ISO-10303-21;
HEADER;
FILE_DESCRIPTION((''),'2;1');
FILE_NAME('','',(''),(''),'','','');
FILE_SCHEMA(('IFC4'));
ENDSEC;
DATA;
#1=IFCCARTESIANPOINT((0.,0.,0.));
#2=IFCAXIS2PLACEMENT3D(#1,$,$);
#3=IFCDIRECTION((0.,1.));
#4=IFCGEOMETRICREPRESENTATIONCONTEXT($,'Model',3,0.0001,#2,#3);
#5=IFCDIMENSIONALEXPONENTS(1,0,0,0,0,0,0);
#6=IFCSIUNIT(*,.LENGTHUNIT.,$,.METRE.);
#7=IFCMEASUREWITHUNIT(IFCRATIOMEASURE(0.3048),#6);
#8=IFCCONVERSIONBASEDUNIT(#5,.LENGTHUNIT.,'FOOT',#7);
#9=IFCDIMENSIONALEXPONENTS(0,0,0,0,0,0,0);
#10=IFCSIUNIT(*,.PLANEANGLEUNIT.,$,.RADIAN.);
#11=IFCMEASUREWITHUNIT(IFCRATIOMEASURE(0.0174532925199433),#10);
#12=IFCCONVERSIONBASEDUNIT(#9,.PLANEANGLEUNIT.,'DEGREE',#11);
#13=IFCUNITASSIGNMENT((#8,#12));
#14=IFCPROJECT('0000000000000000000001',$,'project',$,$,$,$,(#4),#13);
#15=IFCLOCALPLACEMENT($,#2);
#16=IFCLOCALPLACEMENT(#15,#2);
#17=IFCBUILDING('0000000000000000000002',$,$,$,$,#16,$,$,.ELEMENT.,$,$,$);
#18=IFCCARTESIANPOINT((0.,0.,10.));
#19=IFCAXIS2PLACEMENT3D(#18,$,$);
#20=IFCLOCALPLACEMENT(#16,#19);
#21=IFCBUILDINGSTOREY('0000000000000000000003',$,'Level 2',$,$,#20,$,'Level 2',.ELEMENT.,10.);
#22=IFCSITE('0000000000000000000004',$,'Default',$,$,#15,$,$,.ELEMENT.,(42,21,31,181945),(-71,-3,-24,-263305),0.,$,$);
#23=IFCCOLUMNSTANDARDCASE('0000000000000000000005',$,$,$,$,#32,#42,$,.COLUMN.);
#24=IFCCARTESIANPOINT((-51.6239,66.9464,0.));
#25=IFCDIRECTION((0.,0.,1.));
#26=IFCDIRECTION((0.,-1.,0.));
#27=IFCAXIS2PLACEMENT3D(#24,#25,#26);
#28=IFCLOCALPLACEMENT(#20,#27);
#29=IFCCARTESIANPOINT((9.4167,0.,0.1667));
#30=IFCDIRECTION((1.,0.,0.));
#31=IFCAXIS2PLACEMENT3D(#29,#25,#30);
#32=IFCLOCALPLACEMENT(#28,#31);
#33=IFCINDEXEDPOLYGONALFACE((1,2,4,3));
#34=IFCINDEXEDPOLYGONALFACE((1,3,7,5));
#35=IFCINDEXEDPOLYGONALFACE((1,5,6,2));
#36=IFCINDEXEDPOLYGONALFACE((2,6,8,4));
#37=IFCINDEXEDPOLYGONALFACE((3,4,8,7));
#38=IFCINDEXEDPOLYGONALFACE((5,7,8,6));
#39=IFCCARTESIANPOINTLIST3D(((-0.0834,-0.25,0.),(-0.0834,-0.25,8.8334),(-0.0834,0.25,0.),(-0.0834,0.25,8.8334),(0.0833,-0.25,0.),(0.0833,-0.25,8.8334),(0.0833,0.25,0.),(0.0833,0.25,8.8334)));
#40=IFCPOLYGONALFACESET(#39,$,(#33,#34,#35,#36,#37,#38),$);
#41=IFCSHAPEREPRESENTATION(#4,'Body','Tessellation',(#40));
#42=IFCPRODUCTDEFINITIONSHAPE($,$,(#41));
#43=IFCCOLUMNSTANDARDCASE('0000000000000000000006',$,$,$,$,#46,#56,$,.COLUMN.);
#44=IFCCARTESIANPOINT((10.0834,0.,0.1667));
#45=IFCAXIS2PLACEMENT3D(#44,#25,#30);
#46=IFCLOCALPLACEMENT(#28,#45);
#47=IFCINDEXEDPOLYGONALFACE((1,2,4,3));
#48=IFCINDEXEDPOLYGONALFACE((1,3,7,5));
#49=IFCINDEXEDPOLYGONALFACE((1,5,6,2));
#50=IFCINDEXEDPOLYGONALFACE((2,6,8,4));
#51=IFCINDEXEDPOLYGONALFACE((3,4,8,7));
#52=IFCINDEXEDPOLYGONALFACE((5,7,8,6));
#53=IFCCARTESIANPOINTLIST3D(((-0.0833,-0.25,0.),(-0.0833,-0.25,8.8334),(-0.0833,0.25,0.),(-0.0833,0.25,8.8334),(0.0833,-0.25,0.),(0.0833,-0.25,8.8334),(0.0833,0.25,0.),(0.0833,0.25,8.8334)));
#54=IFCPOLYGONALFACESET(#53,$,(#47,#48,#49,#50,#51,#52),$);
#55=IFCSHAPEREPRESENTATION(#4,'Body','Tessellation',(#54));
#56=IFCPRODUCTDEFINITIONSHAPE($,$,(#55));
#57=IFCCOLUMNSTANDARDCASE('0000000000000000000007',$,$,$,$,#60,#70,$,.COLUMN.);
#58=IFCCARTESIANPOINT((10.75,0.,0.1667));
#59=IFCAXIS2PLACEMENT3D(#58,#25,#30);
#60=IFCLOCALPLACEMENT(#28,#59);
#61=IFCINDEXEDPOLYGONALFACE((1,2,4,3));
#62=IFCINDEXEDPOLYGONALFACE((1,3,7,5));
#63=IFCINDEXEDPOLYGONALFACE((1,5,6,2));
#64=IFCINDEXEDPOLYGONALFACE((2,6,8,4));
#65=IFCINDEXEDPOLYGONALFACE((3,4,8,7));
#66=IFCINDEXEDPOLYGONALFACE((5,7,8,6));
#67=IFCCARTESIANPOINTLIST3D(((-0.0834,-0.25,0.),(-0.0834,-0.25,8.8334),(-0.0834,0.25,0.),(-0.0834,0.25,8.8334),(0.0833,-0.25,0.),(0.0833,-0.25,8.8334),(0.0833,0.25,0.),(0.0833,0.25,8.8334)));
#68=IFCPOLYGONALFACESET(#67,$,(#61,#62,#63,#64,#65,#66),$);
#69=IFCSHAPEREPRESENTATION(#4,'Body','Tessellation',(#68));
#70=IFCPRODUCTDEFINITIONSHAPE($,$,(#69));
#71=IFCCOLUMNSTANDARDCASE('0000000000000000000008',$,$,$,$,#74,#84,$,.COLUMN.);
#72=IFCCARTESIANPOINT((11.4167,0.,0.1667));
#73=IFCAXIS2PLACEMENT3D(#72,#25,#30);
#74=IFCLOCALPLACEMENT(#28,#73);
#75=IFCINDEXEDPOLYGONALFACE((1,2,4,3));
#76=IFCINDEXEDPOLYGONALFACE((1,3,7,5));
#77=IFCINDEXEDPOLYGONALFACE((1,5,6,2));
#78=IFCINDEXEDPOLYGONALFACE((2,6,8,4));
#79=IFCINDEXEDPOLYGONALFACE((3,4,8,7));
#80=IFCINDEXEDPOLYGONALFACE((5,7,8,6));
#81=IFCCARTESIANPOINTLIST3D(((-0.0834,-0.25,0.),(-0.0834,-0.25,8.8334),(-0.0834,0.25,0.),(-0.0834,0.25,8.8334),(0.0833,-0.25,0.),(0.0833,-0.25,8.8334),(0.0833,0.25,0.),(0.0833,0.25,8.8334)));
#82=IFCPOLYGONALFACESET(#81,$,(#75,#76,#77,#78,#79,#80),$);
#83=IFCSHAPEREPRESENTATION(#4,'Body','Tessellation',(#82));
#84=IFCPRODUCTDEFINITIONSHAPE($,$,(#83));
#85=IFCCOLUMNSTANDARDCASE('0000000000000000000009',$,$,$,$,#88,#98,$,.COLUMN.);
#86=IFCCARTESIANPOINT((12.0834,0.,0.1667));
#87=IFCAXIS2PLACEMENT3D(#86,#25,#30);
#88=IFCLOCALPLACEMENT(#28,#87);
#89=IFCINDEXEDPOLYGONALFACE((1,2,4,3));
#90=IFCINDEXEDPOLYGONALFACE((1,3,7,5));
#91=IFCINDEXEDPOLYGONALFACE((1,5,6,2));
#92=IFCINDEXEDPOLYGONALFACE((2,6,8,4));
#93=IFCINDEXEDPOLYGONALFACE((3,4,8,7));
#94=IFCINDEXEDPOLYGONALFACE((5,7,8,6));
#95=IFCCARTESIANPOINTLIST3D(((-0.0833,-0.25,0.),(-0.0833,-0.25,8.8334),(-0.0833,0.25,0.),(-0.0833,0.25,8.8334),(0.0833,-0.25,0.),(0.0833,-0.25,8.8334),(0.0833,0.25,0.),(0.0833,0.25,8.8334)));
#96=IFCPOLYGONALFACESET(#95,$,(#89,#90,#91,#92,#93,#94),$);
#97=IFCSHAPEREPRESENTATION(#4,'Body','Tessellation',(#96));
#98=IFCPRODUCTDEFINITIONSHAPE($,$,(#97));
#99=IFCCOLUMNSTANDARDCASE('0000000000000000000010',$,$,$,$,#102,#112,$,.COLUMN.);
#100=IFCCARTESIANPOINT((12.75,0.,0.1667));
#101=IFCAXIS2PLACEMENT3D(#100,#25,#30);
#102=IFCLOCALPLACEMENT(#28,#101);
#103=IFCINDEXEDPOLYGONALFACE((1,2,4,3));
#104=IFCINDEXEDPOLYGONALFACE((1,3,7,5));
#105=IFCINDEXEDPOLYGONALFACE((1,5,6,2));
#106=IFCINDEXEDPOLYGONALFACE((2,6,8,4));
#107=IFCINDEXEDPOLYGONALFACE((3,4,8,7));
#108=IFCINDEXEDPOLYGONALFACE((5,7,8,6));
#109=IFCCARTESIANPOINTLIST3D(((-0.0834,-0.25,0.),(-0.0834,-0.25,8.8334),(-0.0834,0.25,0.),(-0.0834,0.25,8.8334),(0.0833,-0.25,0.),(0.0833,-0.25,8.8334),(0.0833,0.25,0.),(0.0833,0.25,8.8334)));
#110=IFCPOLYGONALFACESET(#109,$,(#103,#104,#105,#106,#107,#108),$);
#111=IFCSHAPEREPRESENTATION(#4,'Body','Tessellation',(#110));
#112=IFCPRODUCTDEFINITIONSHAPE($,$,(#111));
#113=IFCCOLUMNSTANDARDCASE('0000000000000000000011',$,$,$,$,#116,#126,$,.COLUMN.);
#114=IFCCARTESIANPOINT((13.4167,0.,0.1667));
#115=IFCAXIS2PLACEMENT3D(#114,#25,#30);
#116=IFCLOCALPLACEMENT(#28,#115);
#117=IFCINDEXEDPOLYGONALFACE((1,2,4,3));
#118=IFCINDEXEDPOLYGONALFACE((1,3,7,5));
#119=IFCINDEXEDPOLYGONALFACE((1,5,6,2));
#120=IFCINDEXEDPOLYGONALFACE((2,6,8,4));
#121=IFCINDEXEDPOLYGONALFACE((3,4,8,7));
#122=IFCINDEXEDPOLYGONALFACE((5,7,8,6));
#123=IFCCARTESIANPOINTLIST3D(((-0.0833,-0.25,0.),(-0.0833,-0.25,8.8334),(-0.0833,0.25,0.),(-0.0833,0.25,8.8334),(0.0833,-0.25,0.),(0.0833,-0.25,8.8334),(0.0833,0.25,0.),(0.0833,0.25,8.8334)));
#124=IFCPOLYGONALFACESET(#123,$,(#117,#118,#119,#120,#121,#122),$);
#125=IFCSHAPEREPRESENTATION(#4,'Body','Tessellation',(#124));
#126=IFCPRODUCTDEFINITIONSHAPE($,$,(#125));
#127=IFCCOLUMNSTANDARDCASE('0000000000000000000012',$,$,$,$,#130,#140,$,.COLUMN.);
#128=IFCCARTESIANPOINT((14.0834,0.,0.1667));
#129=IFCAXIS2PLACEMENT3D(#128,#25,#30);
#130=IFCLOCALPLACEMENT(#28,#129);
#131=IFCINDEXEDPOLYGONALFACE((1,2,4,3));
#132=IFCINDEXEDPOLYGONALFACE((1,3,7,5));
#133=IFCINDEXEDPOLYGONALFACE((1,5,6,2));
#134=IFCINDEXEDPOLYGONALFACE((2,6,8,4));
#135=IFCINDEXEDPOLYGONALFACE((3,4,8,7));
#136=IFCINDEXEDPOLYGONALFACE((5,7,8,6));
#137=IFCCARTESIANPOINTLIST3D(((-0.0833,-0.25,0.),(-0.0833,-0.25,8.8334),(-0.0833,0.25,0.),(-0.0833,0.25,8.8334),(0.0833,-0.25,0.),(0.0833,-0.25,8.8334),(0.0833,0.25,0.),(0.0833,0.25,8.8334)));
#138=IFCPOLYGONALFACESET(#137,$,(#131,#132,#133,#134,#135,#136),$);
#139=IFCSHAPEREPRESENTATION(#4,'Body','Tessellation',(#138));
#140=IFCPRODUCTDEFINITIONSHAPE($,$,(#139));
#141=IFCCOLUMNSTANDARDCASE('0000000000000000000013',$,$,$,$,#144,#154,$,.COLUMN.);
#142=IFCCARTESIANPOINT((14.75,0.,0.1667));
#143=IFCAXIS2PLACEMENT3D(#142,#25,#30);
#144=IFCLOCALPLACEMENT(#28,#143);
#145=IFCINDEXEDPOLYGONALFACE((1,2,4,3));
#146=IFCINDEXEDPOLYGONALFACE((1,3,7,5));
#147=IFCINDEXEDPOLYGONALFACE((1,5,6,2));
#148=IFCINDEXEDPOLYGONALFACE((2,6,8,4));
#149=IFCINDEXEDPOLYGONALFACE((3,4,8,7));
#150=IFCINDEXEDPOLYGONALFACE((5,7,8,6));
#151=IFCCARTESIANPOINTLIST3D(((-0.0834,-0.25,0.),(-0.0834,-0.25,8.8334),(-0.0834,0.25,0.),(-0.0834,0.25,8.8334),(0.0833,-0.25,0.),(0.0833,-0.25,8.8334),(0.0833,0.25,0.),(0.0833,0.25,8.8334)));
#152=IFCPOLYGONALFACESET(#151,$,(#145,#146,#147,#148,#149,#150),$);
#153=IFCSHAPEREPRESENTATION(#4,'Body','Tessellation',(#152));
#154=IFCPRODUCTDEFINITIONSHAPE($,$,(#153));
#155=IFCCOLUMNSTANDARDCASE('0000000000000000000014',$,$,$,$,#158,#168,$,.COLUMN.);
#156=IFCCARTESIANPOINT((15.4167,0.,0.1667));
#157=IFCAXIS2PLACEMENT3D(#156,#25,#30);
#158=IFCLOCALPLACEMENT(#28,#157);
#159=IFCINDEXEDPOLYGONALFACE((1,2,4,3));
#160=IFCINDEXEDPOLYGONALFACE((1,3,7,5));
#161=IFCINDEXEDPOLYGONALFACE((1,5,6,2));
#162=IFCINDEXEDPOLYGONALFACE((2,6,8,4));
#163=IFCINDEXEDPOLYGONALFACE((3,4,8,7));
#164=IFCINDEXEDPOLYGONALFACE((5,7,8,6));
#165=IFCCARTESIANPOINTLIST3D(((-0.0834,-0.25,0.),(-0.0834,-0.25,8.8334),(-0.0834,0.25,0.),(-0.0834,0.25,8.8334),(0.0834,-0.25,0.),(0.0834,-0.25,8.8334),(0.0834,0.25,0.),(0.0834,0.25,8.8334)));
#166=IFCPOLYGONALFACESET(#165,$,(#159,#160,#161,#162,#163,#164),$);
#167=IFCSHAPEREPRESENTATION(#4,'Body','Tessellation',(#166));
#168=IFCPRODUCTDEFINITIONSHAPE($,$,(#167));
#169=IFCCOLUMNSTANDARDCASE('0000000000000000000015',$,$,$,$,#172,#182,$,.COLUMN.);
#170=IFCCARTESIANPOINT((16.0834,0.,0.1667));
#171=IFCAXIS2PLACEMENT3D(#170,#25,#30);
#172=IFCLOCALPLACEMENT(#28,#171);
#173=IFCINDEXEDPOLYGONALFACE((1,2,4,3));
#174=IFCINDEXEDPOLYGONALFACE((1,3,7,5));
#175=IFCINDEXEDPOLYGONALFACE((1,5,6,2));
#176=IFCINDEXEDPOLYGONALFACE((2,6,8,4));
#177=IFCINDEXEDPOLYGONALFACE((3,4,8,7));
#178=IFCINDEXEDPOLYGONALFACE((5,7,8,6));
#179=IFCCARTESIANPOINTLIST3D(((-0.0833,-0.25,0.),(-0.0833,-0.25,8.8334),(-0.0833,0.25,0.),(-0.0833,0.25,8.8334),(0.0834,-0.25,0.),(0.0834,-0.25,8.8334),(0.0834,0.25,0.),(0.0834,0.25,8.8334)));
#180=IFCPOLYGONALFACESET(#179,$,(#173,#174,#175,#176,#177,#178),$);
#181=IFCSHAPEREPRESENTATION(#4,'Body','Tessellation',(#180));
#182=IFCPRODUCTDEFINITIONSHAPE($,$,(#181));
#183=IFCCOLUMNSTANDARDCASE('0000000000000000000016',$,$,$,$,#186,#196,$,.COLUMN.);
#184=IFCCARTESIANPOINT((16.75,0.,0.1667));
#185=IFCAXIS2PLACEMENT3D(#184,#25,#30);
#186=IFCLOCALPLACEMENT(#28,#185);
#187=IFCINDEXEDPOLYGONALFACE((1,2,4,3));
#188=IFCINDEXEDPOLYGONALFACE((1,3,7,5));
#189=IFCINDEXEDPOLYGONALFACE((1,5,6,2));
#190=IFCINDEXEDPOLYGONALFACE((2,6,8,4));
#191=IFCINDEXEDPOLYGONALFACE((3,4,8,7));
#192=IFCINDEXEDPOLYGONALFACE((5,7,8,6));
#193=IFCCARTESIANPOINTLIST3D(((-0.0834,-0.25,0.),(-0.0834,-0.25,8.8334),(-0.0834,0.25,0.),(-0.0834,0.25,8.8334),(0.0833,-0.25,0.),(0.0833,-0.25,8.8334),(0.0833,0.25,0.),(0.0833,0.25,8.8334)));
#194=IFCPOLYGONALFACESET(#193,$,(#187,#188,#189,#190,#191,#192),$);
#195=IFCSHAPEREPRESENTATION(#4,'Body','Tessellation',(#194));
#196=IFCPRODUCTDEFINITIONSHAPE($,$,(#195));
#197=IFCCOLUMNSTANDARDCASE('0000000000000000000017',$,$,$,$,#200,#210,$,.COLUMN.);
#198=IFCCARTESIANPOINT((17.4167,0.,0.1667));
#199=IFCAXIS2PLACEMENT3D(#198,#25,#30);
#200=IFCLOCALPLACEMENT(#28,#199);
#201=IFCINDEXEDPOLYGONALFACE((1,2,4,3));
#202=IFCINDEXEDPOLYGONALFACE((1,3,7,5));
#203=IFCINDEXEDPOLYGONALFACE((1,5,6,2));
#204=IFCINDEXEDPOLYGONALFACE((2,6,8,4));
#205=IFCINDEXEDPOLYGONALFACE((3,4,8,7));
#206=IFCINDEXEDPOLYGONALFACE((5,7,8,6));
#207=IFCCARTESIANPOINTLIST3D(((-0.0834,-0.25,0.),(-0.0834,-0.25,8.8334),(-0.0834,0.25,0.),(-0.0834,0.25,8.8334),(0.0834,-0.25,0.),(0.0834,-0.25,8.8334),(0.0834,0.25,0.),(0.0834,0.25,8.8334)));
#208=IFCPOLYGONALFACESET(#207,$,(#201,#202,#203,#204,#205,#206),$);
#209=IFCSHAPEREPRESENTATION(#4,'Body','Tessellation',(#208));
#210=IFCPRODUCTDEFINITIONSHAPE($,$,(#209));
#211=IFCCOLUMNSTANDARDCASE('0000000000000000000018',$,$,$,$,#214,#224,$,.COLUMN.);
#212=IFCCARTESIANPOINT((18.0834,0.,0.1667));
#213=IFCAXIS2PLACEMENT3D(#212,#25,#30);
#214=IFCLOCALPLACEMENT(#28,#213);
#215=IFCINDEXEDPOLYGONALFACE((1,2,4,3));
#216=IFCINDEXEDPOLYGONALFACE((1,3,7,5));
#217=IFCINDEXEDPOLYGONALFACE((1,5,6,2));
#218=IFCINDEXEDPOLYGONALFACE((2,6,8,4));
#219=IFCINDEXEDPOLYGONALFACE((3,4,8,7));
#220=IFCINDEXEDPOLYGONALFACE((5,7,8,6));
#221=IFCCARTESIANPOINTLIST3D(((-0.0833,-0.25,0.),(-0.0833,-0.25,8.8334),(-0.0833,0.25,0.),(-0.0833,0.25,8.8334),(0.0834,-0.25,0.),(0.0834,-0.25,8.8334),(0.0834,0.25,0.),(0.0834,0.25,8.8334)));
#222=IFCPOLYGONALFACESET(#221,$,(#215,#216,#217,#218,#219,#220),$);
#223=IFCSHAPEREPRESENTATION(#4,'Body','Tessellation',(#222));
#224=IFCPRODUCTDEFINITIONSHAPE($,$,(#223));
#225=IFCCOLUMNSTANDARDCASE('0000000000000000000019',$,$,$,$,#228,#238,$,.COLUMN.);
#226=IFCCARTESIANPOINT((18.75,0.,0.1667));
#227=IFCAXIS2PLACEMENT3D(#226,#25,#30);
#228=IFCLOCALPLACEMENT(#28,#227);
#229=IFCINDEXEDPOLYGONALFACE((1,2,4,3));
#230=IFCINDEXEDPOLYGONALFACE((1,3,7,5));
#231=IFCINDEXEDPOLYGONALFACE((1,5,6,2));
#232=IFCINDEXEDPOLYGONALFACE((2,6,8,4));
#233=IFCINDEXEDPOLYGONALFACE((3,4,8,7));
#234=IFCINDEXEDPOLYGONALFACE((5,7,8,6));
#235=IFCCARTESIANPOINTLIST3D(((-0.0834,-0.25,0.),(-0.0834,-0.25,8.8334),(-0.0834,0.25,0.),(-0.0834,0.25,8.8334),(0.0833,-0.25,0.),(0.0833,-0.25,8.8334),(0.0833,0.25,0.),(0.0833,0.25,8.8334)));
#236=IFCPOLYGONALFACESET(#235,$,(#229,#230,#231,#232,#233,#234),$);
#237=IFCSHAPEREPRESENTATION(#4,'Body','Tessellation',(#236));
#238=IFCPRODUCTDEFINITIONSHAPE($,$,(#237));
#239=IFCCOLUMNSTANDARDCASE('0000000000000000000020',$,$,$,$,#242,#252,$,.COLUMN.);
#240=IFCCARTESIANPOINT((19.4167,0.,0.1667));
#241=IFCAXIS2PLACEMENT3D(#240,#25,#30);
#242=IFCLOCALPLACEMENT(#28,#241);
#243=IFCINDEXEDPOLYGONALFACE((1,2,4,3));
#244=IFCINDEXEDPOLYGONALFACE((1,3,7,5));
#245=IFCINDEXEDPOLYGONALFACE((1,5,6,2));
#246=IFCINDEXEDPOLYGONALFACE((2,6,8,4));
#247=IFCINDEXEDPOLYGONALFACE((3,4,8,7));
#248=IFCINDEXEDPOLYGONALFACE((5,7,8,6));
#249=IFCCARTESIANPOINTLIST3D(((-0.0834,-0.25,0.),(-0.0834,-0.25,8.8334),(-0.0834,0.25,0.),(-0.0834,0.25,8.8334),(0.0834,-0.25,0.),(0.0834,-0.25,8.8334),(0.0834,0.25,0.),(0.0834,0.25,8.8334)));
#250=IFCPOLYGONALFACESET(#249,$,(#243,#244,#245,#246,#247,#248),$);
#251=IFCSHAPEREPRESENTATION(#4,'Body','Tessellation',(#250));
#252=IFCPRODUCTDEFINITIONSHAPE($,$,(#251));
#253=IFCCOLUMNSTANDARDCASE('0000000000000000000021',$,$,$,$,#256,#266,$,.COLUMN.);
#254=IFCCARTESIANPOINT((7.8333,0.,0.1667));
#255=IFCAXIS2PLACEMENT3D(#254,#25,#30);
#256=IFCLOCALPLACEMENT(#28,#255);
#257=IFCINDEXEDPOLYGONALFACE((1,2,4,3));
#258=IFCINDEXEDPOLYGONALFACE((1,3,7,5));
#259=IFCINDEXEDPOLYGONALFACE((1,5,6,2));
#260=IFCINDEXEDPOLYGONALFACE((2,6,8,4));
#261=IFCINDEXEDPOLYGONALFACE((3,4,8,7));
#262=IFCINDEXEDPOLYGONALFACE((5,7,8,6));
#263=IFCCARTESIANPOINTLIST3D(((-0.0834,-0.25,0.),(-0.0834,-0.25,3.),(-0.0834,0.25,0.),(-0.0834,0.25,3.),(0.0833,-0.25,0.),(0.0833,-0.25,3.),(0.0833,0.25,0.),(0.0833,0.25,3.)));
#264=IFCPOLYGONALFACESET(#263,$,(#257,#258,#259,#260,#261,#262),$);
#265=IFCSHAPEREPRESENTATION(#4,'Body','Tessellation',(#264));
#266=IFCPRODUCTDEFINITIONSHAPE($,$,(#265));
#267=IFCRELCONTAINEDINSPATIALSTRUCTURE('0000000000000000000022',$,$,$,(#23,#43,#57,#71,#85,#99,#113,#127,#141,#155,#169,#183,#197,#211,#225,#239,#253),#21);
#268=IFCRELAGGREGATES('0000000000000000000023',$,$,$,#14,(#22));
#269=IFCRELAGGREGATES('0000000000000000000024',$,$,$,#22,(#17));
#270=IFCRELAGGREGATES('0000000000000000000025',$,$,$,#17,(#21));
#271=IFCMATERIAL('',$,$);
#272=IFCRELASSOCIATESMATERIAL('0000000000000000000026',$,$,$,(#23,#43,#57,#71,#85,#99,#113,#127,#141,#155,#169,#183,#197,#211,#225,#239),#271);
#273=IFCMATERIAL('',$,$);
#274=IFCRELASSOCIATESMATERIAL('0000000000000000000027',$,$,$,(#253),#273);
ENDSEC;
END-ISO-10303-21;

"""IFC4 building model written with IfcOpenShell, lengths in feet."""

from ifc_helpers import new_model, entity, si_unit, converted_unit, direction, frame, origin, place, context, project, spatial, rectangle, extrude, material, element, save


model = new_model("IFC4")

# Units and contexts
model_context = context("Model", 3, precision=0.0001, world=origin(), true_north=direction((0.0, 1.0)))
ifc_project = project(units=[converted_unit("LENGTHUNIT", "FOOT", entity("IfcRatioMeasure", 0.3048), si_unit("LENGTHUNIT", "METRE"), dimensions=[1, 0, 0, 0, 0, 0, 0]), converted_unit("PLANEANGLEUNIT", "DEGREE", entity("IfcRatioMeasure", 0.0174532925199433), si_unit("PLANEANGLEUNIT", "RADIAN"), dimensions=[0, 0, 0, 0, 0, 0, 0])], contexts=[model_context])

# Site, building, storey
site_placement = place(None, origin())
site = spatial("IfcSite", under=ifc_project, at=site_placement, Name="Default", CompositionType="ELEMENT", RefLatitude=(42, 21, 31, 181945), RefLongitude=(-71, -3, -24, -263305), RefElevation=0.0)
building_placement = place(site_placement, origin())
building = spatial("IfcBuilding", under=site, at=building_placement, CompositionType="ELEMENT")
storey_placement = place(building_placement, frame((0.0, 0.0, 10.0)))
storey = spatial("IfcBuildingStorey", under=building, at=storey_placement, Name="Level 2", LongName="Level 2", CompositionType="ELEMENT", Elevation=10.0)

# Columns
ifc_material_1 = material(Name="")
placement = place(storey_placement, frame((-51.6239, 66.9464, 0.0), z_axis=(0.0, 0.0, 1.0), x_axis=(0.0, -1.0, 0.0)))
for number, where, z_axis, x_axis in (
    (1, (9.4167, 0.0, 0.1667), (0.0, 0.0, 1.0), (1.0, 0.0, 0.0)),
    (2, (10.0834, 0.0, 0.1667), (0.0, 0.0, 1.0), (1.0, 0.0, 0.0)),
    (3, (10.75, 0.0, 0.1667), (0.0, 0.0, 1.0), (1.0, 0.0, 0.0)),
    (4, (11.4167, 0.0, 0.1667), (0.0, 0.0, 1.0), (1.0, 0.0, 0.0)),
    (5, (12.0834, 0.0, 0.1667), (0.0, 0.0, 1.0), (1.0, 0.0, 0.0)),
    (6, (12.75, 0.0, 0.1667), (0.0, 0.0, 1.0), (1.0, 0.0, 0.0)),
    (7, (13.4167, 0.0, 0.1667), (0.0, 0.0, 1.0), (1.0, 0.0, 0.0)),
    (8, (14.0834, 0.0, 0.1667), (0.0, 0.0, 1.0), (1.0, 0.0, 0.0)),
    (9, (14.75, 0.0, 0.1667), (0.0, 0.0, 1.0), (1.0, 0.0, 0.0)),
    (10, (15.4167, 0.0, 0.1667), (0.0, 0.0, 1.0), (1.0, 0.0, 0.0)),
    (11, (16.0834, 0.0, 0.1667), (0.0, 0.0, 1.0), (1.0, 0.0, 0.0)),
    (12, (16.75, 0.0, 0.1667), (0.0, 0.0, 1.0), (1.0, 0.0, 0.0)),
    (13, (17.4167, 0.0, 0.1667), (0.0, 0.0, 1.0), (1.0, 0.0, 0.0)),
    (14, (18.0834, 0.0, 0.1667), (0.0, 0.0, 1.0), (1.0, 0.0, 0.0)),
    (15, (18.75, 0.0, 0.1667), (0.0, 0.0, 1.0), (1.0, 0.0, 0.0)),
    (16, (19.4167, 0.0, 0.1667), (0.0, 0.0, 1.0), (1.0, 0.0, 0.0)),
):
    element("IfcColumnStandardCase", number, at=place(placement, frame(where, z_axis=z_axis, x_axis=x_axis)), inside=storey, material=ifc_material_1, PredefinedType="COLUMN", context=model_context, shape_type="SweptSolid", body=[
        extrude(rectangle(XDim=0.1667, YDim=0.5), origin(), (0.0, 0.0, 1.0), 8.8334),
    ])
ifc_material_2 = material(Name="")
for number, where, z_axis, x_axis in (
    (17, (7.8333, 0.0, 0.1667), (0.0, 0.0, 1.0), (1.0, 0.0, 0.0)),
):
    element("IfcColumnStandardCase", number, at=place(placement, frame(where, z_axis=z_axis, x_axis=x_axis)), inside=storey, material=ifc_material_2, PredefinedType="COLUMN", context=model_context, shape_type="SweptSolid", body=[
        extrude(rectangle(XDim=0.1667, YDim=0.5), origin(), (0.0, 0.0, 1.0), 3.0),
    ])

save(model, "model.ifc")
